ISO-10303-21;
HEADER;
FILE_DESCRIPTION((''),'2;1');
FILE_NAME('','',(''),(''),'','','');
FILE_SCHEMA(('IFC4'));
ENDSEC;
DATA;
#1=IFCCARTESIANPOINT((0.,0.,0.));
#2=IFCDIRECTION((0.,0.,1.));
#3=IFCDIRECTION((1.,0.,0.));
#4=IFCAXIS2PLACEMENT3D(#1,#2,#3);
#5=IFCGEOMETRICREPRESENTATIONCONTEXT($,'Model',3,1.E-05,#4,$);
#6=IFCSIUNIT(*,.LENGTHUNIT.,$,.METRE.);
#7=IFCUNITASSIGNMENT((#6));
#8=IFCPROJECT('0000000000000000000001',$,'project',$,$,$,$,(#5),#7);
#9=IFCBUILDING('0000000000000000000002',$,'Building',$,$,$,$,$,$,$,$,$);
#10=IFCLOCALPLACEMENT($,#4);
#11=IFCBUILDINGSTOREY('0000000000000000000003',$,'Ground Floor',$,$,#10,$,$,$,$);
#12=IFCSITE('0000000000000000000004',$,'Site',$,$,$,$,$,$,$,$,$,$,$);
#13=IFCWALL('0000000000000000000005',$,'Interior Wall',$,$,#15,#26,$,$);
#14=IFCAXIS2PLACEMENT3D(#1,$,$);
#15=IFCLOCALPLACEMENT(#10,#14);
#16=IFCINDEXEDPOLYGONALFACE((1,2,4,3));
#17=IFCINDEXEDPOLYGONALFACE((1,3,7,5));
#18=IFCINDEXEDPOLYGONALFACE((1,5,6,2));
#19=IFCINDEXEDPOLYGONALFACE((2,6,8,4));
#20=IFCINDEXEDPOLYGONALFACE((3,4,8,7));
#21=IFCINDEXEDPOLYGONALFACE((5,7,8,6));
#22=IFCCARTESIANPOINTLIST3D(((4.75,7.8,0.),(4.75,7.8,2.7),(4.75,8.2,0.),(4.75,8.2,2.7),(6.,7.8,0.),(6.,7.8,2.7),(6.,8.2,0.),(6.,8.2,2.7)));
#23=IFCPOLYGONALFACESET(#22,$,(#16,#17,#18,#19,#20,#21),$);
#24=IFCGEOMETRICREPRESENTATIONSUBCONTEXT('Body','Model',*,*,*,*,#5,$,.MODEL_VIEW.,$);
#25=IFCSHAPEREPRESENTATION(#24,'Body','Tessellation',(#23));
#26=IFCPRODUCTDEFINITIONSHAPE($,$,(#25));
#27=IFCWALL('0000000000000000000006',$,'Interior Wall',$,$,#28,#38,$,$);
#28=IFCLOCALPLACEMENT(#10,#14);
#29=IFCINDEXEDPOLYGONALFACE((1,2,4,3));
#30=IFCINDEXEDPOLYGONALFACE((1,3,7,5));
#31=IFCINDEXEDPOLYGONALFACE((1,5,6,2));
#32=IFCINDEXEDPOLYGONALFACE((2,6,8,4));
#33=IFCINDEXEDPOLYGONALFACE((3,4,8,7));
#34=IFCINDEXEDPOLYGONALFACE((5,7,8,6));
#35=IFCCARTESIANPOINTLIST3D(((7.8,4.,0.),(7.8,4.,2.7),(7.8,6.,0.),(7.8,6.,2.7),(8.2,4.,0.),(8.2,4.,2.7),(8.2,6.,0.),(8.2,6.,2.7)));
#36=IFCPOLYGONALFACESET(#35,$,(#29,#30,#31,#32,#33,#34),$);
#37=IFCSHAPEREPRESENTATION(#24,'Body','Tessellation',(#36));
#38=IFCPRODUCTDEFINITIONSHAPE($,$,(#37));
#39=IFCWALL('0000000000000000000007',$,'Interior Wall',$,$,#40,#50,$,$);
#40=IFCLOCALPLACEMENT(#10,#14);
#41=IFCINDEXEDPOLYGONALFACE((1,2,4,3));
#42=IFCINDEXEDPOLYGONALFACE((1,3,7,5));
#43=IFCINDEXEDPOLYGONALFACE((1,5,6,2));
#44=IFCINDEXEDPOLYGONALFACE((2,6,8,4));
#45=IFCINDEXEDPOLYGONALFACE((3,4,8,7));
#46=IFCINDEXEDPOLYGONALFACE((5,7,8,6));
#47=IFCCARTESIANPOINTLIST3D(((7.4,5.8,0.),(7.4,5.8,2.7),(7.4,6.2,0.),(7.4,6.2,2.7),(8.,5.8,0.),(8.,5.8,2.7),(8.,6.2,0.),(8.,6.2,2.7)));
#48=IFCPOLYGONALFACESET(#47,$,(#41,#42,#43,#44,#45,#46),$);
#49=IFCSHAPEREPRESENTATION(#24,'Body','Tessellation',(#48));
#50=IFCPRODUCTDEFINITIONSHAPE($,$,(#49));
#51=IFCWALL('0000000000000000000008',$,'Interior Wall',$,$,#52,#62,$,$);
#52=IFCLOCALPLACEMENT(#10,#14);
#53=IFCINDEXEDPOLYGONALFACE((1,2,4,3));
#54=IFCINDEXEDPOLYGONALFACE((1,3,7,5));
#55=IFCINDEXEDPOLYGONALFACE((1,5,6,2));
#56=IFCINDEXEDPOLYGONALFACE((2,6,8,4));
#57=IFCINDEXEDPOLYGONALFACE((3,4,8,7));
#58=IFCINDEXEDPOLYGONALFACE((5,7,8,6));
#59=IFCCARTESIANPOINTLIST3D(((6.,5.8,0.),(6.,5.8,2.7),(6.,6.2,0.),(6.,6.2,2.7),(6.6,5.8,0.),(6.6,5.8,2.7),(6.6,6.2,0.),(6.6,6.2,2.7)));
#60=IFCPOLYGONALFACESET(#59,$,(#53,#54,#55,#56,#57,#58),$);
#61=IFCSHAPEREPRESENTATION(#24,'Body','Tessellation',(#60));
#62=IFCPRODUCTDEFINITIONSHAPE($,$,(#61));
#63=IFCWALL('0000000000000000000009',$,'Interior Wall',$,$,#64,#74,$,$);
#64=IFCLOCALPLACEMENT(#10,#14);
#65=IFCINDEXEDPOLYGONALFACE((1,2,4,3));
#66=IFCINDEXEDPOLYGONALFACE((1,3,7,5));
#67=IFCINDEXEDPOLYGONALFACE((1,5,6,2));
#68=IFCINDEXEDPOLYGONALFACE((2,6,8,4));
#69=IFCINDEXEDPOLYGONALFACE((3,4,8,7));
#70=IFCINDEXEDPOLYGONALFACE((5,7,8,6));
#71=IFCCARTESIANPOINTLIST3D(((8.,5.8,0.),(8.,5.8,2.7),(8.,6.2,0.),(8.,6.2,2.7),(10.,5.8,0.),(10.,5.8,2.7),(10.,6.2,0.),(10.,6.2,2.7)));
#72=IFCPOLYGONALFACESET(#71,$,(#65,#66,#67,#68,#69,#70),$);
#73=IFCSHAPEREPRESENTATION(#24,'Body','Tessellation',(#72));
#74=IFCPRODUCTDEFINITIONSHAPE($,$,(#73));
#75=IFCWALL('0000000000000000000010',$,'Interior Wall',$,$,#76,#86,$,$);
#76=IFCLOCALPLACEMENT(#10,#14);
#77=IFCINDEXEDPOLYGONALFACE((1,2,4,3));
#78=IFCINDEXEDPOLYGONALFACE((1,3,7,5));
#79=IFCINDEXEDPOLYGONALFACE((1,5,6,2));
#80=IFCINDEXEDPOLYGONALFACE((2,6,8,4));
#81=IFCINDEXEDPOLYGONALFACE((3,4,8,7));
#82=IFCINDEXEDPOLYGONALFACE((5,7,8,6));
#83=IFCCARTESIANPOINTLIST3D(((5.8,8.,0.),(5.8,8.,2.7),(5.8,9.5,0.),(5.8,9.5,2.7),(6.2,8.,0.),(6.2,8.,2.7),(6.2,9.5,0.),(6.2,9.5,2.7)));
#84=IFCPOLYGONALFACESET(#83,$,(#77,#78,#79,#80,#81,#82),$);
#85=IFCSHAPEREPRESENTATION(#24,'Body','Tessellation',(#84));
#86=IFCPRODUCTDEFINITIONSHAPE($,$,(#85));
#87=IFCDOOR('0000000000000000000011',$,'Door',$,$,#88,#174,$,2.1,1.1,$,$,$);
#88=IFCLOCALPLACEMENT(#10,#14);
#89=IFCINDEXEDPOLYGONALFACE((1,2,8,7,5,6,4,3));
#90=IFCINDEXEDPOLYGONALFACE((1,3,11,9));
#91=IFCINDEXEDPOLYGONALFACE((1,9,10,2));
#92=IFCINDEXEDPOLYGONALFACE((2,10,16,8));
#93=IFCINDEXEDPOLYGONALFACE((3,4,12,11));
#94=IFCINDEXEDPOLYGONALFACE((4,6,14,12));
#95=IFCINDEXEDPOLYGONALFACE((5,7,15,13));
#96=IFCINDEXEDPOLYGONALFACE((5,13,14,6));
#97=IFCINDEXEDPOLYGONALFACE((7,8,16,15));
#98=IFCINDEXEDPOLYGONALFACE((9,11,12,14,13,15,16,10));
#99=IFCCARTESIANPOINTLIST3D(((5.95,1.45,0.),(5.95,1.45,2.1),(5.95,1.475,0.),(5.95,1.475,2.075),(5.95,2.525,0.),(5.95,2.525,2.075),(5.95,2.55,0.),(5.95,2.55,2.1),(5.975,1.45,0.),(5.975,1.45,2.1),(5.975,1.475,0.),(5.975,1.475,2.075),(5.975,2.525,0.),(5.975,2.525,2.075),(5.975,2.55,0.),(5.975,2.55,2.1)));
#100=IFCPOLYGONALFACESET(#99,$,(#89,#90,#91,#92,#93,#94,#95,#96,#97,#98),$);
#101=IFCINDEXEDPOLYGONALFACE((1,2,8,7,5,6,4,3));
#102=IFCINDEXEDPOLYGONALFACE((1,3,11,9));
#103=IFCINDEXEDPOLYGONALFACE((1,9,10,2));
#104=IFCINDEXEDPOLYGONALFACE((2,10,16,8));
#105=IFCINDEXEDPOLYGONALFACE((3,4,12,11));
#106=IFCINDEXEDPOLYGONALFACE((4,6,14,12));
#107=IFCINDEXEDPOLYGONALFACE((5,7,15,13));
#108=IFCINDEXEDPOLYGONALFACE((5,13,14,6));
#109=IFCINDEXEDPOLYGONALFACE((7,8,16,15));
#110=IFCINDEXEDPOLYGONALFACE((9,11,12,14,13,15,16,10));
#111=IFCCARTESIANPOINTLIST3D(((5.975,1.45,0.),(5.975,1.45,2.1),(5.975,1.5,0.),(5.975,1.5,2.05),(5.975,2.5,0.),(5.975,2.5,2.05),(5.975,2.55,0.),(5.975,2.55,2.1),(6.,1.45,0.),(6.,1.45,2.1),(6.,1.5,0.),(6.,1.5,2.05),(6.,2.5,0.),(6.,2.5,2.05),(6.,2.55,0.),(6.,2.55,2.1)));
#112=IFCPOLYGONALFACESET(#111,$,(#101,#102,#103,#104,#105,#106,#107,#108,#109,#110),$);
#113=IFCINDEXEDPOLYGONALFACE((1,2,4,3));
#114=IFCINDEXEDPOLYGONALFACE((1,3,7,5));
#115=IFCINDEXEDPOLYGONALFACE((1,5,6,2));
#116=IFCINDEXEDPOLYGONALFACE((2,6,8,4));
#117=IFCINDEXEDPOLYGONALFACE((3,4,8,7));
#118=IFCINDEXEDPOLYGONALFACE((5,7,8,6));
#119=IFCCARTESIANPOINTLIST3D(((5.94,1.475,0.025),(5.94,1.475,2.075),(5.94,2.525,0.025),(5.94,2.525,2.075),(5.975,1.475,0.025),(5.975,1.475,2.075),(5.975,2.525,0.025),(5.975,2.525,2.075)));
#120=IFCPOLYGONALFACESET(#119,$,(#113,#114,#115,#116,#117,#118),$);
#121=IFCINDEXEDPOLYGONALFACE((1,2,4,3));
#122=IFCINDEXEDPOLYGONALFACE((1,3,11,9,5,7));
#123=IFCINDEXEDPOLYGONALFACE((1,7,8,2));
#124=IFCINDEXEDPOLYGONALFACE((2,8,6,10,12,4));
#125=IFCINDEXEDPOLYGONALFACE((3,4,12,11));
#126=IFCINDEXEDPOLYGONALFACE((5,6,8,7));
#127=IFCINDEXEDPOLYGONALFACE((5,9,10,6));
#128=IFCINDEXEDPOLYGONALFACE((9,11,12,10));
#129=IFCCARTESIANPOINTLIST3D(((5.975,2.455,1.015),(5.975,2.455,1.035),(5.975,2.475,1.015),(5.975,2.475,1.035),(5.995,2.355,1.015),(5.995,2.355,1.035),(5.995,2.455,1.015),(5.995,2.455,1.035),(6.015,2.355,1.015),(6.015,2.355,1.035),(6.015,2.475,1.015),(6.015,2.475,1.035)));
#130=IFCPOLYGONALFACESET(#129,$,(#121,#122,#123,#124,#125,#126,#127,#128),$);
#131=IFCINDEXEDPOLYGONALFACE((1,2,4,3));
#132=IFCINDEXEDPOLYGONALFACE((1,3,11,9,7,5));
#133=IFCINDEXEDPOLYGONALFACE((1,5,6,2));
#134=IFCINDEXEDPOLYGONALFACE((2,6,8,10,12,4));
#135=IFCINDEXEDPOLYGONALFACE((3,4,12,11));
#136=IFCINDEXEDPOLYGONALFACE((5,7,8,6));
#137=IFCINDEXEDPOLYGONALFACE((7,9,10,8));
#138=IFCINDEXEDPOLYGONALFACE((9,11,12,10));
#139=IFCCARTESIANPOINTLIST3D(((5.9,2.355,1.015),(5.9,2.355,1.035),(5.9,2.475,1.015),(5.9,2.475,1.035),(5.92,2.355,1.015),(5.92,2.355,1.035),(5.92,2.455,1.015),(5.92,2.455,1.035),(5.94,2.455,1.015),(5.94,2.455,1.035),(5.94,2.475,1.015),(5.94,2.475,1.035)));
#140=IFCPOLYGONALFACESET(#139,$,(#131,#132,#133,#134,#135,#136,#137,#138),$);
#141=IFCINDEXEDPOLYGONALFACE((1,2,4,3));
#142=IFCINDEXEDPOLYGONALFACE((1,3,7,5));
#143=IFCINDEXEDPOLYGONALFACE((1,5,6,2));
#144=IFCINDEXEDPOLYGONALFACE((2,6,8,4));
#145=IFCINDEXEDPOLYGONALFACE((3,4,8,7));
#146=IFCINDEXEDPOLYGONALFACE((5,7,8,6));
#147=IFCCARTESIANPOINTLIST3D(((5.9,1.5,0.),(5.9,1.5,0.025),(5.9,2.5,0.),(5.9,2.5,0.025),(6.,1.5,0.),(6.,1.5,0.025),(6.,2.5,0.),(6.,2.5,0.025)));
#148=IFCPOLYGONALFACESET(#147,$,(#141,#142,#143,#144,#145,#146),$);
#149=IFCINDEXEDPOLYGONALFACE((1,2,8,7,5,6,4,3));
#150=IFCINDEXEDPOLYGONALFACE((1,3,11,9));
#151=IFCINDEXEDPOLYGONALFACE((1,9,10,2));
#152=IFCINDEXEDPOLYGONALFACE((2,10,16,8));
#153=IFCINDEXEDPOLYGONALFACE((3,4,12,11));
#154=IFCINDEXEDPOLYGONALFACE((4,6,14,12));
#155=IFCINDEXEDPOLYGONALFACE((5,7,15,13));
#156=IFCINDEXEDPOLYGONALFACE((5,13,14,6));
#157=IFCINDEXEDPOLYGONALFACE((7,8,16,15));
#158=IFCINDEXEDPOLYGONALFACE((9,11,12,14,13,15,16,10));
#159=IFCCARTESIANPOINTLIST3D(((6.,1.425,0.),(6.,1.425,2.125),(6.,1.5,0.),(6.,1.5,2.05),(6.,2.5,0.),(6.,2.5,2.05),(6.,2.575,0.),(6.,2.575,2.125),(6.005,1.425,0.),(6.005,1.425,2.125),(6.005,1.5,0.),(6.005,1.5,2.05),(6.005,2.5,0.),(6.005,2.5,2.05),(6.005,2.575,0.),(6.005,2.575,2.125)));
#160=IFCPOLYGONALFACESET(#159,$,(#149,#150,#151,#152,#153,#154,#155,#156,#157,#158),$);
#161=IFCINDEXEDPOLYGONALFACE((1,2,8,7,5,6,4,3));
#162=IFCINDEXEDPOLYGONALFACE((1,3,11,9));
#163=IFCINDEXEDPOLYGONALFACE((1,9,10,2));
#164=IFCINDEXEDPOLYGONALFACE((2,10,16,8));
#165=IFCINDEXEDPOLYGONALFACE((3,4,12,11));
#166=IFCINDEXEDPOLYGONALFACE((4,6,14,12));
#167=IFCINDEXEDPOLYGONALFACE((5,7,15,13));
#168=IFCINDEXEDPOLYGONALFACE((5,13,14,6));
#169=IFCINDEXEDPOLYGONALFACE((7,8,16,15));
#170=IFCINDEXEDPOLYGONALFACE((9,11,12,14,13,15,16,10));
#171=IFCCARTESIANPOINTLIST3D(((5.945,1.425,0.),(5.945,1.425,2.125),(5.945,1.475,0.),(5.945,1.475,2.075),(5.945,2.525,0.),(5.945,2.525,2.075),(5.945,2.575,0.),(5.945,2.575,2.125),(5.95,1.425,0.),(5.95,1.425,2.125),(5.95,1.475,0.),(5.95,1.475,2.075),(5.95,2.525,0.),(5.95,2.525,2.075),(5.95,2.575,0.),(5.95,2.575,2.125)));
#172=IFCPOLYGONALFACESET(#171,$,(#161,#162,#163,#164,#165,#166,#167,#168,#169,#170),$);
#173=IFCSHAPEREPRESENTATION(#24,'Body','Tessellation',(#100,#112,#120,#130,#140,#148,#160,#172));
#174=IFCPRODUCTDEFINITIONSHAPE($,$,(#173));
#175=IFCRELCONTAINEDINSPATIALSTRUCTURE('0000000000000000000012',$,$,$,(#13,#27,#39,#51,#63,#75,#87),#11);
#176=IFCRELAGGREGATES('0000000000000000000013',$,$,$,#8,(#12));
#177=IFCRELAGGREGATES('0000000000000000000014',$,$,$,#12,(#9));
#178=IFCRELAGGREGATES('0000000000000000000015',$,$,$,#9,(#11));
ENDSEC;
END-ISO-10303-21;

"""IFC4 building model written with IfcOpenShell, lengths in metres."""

from ifc_helpers import new_model, si_unit, frame, origin_with_axes, place, context, subcontext, project, spatial, line, indexed_curve, outline, extrude, element, save


model = new_model("IFC4")

# Units and contexts
model_context = context("Model", 3, precision=1e-05, world=origin_with_axes())
body_context = subcontext(model_context, "Body", "Model", "MODEL_VIEW")
ifc_project = project(units=[si_unit("LENGTHUNIT", "METRE")], contexts=[model_context])

# Site, building, storey
site = spatial("IfcSite", under=ifc_project, Name="Site")
building = spatial("IfcBuilding", under=site, Name="Building")
storey_placement = place(None, origin_with_axes())
storey = spatial("IfcBuildingStorey", under=building, at=storey_placement, Name="Ground Floor")

# Walls
wall_1_placement = place(storey_placement, frame((6.0, 8.0, 0.0), z_axis=(0.0, 0.0, 1.0), x_axis=(-1.0, 0.0, 0.0)))
element("IfcWall", 1, at=wall_1_placement, inside=storey, Name="Interior Wall", context=body_context, shape_type="SweptSolid", body=[
    extrude(outline(indexed_curve([(0.0, 0.0), (0.0, 0.4), (1.25, 0.4), (1.25, 0.0), (0.0, 0.0)], self_intersect=False)), frame((0.0, -0.2, 0.0), z_axis=(0.0, 0.0, 1.0), x_axis=(1.0, 0.0, 0.0)), (0.0, 0.0, 1.0), 2.7),
])
wall_2_placement = place(storey_placement, frame((8.0, 4.0, 0.0), z_axis=(0.0, 0.0, 1.0), x_axis=(0.0, 1.0, 0.0)))
element("IfcWall", 2, at=wall_2_placement, inside=storey, Name="Interior Wall", context=body_context, shape_type="SweptSolid", body=[
    extrude(outline(indexed_curve([(0.0, 0.0), (0.0, 0.4), (2.0, 0.4), (2.0, 0.0), (0.0, 0.0)], self_intersect=False)), frame((0.0, -0.2, 0.0), z_axis=(0.0, 0.0, 1.0), x_axis=(1.0, 0.0, 0.0)), (0.0, 0.0, 1.0), 2.7),
])
for number, where, z_axis, x_axis, name in (
    (3, (8.0, 6.0, 0.0), (0.0, 0.0, 1.0), (-1.0, 0.0, 0.0), "Interior Wall"),
    (4, (6.6, 6.0, 0.0), (0.0, 0.0, 1.0), (-1.0, 0.0, 0.0), "Interior Wall"),
):
    element("IfcWall", number, at=place(storey_placement, frame(where, z_axis=z_axis, x_axis=x_axis)), inside=storey, Name=name, context=body_context, shape_type="SweptSolid", body=[
        extrude(outline(indexed_curve([(0.0, 0.0), (0.0, 0.4), (0.6, 0.4), (0.6, 0.0), (0.0, 0.0)], self_intersect=False)), frame((0.0, -0.2, 0.0), z_axis=(0.0, 0.0, 1.0), x_axis=(1.0, 0.0, 0.0)), (0.0, 0.0, 1.0), 2.7),
    ])
wall_3_placement = place(storey_placement, frame((10.0, 6.0, 0.0), z_axis=(0.0, 0.0, 1.0), x_axis=(-1.0, 0.0, 0.0)))
element("IfcWall", 5, at=wall_3_placement, inside=storey, Name="Interior Wall", context=body_context, shape_type="SweptSolid", body=[
    extrude(outline(indexed_curve([(0.0, 0.0), (0.0, 0.4), (2.0, 0.4), (2.0, 0.0), (0.0, 0.0)], self_intersect=False)), frame((0.0, -0.2, 0.0), z_axis=(0.0, 0.0, 1.0), x_axis=(1.0, 0.0, 0.0)), (0.0, 0.0, 1.0), 2.7),
])
wall_4_placement = place(storey_placement, frame((6.0, 9.5, 0.0), z_axis=(0.0, 0.0, 1.0), x_axis=(0.0, -1.0, 0.0)))
element("IfcWall", 6, at=wall_4_placement, inside=storey, Name="Interior Wall", context=body_context, shape_type="SweptSolid", body=[
    extrude(outline(indexed_curve([(0.0, 0.0), (0.0, 0.4), (1.5, 0.4), (1.5, 0.0), (0.0, 0.0)], self_intersect=False)), frame((0.0, -0.2, 0.0), z_axis=(0.0, 0.0, 1.0), x_axis=(1.0, 0.0, 0.0)), (0.0, 0.0, 1.0), 2.7),
])

# Door
door_1_placement = place(storey_placement, frame((6.0, 1.45, 0.0), z_axis=(0.0, 0.0, 1.0), x_axis=(0.0, 1.0, 0.0)))
element("IfcDoor", 7, at=door_1_placement, inside=storey, Name="Door", OverallHeight=2.1, OverallWidth=1.1, context=body_context, shape_type="SweptSolid", body=[
    extrude(outline(indexed_curve([(0.0, 0.0), (0.0, 2.1), (1.1, 2.1), (1.1, 0.0), (1.075, 0.0), (1.075, 2.075), (0.025, 2.075), (0.025, 0.0)], segments=[line(1, 2, 3, 4, 5, 6, 7, 8, 1)])), frame((0.0, 0.025, 0.0), z_axis=(0.0, -1.0, 0.0), x_axis=(1.0, 0.0, 0.0)), (0.0, 0.0, -1.0), 0.025),
    extrude(outline(indexed_curve([(0.0, 0.0), (0.0, 2.1), (1.1, 2.1), (1.1, 0.0), (1.05, 0.0), (1.05, 2.05), (0.05, 2.05), (0.05, 0.0)], segments=[line(1, 2, 3, 4, 5, 6, 7, 8, 1)])), frame((0.0, 0.0, 0.0), z_axis=(0.0, -1.0, 0.0), x_axis=(1.0, 0.0, 0.0)), (0.0, 0.0, -1.0), 0.025),
    extrude(outline(indexed_curve([(0.0, 0.0), (1.05, 0.0), (1.05, 0.035), (0.0, 0.035)], segments=[line(1, 2, 3, 4, 1)])), frame((0.025, 0.025, 0.025), z_axis=(0.0, 0.0, 1.0), x_axis=(1.0, 0.0, 0.0)), (0.0, 0.0, 1.0), 2.05),
    extrude(outline(indexed_curve([(0.0, 0.0), (0.0, -0.04), (-0.12, -0.04), (-0.12, -0.02), (-0.02, -0.02), (-0.02, 0.0)], segments=[line(1, 2, 3, 4, 5, 6, 1)])), frame((1.025, 0.025, 1.015), z_axis=(0.0, 0.0, 1.0), x_axis=(1.0, 0.0, 0.0)), (0.0, 0.0, 1.0), 0.02),
    extrude(outline(indexed_curve([(0.0, 0.0), (0.0, 0.04), (-0.12, 0.04), (-0.12, 0.02), (-0.02, 0.02), (-0.02, 0.0)], segments=[line(1, 2, 3, 4, 5, 6, 1)])), frame((1.025, 0.06, 1.015), z_axis=(0.0, 0.0, 1.0), x_axis=(1.0, 0.0, 0.0)), (0.0, 0.0, 1.0), 0.02),
    extrude(outline(indexed_curve([(0.0, 0.0), (1.0, 0.0), (1.0, 0.1), (0.0, 0.1)], segments=[line(1, 2, 3, 4, 1)])), frame((0.05, 0.0, 0.0), z_axis=(0.0, 0.0, 1.0), x_axis=(1.0, 0.0, 0.0)), (0.0, 0.0, 1.0), 0.025),
    extrude(outline(indexed_curve([(0.0, 0.0), (0.0, 2.125), (1.15, 2.125), (1.15, 0.0), (1.075, 0.0), (1.075, 2.05), (0.075, 2.05), (0.075, 0.0)], segments=[line(1, 2, 3, 4, 5, 6, 7, 8, 1)])), frame((-0.025, -0.005, 0.0), z_axis=(0.0, -1.0, 0.0), x_axis=(1.0, 0.0, 0.0)), (0.0, 0.0, -1.0), 0.005),
    extrude(outline(indexed_curve([(0.0, 0.0), (0.0, 2.125), (1.15, 2.125), (1.15, 0.0), (1.1, 0.0), (1.1, 2.075), (0.05, 2.075), (0.05, 0.0)], segments=[line(1, 2, 3, 4, 5, 6, 7, 8, 1)])), frame((-0.025, 0.05, 0.0), z_axis=(0.0, -1.0, 0.0), x_axis=(1.0, 0.0, 0.0)), (0.0, 0.0, -1.0), 0.005),
])

save(model, "model.ifc")
